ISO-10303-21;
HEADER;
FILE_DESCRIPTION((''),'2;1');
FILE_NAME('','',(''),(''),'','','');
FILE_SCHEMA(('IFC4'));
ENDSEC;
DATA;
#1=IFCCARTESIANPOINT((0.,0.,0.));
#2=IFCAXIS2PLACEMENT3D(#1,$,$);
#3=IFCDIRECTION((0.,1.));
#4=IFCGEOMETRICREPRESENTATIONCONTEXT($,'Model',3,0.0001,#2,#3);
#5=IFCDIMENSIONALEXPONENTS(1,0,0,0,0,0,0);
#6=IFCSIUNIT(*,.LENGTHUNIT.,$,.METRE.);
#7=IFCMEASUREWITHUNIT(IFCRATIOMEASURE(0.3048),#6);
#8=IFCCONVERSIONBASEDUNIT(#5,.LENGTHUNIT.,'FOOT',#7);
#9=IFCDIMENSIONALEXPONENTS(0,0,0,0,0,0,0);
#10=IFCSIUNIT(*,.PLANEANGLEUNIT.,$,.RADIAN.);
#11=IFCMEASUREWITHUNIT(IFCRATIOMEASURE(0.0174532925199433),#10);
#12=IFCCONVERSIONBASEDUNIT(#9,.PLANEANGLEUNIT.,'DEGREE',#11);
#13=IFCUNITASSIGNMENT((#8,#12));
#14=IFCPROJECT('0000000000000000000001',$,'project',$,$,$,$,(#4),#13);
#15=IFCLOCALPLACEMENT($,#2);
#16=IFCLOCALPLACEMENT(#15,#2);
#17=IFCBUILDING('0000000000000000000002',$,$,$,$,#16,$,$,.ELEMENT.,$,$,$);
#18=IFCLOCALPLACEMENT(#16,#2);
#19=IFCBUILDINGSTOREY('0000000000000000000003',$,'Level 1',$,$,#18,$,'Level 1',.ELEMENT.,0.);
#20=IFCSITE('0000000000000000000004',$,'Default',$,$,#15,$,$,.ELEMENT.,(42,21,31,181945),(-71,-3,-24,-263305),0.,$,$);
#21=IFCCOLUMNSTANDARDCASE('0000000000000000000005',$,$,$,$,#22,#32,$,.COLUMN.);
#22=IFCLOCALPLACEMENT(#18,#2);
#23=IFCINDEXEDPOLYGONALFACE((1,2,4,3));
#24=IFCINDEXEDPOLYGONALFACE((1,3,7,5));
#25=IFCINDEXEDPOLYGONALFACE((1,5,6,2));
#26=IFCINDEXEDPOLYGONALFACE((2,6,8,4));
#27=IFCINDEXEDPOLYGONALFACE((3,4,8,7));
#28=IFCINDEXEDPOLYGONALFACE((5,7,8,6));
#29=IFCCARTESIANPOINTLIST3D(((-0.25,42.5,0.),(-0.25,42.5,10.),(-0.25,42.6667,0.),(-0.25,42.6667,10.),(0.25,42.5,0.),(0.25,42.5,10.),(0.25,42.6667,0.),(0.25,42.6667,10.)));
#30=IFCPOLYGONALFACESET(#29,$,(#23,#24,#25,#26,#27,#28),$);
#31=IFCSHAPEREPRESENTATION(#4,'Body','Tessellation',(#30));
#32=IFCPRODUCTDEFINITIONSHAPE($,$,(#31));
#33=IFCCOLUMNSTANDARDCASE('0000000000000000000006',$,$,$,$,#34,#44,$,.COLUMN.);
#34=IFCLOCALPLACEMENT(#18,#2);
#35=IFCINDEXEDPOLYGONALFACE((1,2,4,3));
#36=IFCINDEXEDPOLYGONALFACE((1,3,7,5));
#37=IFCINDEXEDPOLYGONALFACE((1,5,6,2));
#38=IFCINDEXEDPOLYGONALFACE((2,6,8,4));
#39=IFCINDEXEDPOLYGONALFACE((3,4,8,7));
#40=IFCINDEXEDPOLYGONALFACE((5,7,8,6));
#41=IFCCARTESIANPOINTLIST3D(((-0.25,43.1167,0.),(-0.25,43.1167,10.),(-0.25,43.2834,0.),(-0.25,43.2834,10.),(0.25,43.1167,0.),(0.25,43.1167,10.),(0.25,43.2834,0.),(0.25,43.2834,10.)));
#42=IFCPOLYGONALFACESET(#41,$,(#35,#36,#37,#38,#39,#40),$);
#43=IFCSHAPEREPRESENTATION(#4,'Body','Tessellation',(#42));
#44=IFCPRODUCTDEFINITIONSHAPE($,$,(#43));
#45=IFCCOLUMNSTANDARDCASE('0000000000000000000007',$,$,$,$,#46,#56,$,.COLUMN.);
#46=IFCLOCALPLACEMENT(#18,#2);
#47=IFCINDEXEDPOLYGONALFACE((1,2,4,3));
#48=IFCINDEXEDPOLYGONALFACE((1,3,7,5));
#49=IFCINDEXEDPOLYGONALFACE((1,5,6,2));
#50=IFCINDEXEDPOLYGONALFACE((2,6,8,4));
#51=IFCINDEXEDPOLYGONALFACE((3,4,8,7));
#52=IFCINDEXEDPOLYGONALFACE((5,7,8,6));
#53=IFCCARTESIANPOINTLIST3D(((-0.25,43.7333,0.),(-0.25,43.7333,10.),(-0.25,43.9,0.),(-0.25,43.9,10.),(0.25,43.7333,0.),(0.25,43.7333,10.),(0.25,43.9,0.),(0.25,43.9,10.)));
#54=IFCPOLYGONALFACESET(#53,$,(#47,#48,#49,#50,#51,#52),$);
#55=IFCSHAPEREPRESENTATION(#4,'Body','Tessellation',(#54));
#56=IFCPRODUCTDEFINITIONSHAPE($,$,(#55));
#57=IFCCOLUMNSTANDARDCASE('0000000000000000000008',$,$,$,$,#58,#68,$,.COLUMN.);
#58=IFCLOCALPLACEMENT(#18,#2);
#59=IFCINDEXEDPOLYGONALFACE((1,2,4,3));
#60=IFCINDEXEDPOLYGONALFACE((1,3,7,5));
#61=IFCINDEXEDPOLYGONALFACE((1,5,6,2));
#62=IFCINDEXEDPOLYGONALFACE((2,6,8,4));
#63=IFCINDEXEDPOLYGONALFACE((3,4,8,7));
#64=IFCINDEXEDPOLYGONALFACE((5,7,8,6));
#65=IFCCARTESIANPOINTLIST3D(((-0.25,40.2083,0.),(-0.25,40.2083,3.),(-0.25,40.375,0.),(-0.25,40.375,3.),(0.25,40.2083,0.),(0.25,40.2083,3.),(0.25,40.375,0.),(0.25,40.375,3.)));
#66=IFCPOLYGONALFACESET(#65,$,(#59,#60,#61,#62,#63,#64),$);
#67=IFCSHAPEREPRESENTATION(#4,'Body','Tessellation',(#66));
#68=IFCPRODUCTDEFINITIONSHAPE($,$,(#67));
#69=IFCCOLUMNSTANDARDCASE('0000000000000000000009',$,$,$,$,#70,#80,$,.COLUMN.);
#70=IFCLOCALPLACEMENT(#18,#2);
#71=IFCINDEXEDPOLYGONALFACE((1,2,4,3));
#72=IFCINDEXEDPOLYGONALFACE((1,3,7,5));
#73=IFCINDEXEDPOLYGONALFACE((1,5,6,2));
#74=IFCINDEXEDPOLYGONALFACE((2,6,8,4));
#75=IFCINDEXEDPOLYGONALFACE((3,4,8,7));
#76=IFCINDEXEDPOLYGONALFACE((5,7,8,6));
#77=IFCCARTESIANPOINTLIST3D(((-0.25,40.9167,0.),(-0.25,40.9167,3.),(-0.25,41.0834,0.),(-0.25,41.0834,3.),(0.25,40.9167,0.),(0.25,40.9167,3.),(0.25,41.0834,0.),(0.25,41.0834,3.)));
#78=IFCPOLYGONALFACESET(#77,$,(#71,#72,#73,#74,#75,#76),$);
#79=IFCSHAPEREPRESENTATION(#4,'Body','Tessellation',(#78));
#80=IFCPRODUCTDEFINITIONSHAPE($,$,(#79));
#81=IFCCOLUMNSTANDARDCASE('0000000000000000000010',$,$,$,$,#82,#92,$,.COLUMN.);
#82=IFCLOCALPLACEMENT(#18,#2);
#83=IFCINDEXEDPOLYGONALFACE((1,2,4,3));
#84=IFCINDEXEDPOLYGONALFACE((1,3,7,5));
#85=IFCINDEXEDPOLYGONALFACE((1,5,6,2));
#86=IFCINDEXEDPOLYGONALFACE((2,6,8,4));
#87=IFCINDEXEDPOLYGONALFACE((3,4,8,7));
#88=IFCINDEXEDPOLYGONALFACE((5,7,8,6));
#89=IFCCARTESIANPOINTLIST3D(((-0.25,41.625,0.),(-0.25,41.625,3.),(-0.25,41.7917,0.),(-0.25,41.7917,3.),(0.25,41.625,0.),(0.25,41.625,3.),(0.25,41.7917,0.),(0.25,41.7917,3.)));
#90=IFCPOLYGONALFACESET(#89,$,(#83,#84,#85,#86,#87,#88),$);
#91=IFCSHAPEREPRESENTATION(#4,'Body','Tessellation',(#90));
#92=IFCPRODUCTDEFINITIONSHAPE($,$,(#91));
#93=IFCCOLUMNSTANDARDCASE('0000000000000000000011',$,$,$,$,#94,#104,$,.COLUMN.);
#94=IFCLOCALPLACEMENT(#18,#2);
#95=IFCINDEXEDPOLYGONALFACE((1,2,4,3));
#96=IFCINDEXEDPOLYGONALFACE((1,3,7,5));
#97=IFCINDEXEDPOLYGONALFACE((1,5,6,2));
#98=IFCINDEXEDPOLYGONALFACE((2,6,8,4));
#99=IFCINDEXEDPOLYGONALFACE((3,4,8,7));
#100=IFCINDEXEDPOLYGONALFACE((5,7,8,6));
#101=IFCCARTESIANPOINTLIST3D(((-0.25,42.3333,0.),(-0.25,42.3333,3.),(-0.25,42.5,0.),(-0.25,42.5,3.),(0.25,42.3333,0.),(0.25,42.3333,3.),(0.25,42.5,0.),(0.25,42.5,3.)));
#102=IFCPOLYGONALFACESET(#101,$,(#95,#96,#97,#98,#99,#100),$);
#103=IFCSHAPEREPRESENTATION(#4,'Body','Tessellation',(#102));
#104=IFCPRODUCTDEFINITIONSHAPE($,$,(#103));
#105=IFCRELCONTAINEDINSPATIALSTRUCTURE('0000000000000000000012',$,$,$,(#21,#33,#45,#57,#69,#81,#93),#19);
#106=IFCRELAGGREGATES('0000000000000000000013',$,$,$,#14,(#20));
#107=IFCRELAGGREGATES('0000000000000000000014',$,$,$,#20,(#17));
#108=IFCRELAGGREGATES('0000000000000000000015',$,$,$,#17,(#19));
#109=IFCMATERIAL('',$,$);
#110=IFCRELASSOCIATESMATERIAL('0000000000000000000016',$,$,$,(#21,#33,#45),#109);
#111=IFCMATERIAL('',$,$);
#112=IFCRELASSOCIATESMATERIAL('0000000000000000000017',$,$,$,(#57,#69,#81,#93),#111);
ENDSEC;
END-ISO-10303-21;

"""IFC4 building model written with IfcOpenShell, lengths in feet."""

from ifc_helpers import new_model, entity, si_unit, converted_unit, direction, frame, origin, place, context, project, spatial, rectangle, extrude, material, element, save


model = new_model("IFC4")

# Units and contexts
model_context = context("Model", 3, precision=0.0001, world=origin(), true_north=direction((0.0, 1.0)))
ifc_project = project(units=[converted_unit("LENGTHUNIT", "FOOT", entity("IfcRatioMeasure", 0.3048), si_unit("LENGTHUNIT", "METRE"), dimensions=[1, 0, 0, 0, 0, 0, 0]), converted_unit("PLANEANGLEUNIT", "DEGREE", entity("IfcRatioMeasure", 0.0174532925199433), si_unit("PLANEANGLEUNIT", "RADIAN"), dimensions=[0, 0, 0, 0, 0, 0, 0])], contexts=[model_context])

# Site, building, storey
site_placement = place(None, origin())
site = spatial("IfcSite", under=ifc_project, at=site_placement, Name="Default", CompositionType="ELEMENT", RefLatitude=(42, 21, 31, 181945), RefLongitude=(-71, -3, -24, -263305), RefElevation=0.0)
building_placement = place(site_placement, origin())
building = spatial("IfcBuilding", under=site, at=building_placement, CompositionType="ELEMENT")
storey_placement = place(building_placement, origin())
storey = spatial("IfcBuildingStorey", under=building, at=storey_placement, Name="Level 1", LongName="Level 1", CompositionType="ELEMENT", Elevation=0.0)

# Columns
ifc_material_1 = material(Name="")
placement = place(storey_placement, frame((0.0, -0.25, 0.0), z_axis=(0.0, 0.0, 1.0), x_axis=(0.0, 1.0, 0.0)))
for number, where, z_axis, x_axis in (
    (1, (42.8334, 0.0, 0.0), (0.0, 0.0, 1.0), (1.0, 0.0, 0.0)),
    (2, (43.45, 0.0, 0.0), (0.0, 0.0, 1.0), (1.0, 0.0, 0.0)),
    (3, (44.0667, 0.0, 0.0), (0.0, 0.0, 1.0), (1.0, 0.0, 0.0)),
):
    element("IfcColumnStandardCase", number, at=place(placement, frame(where, z_axis=z_axis, x_axis=x_axis)), inside=storey, material=ifc_material_1, PredefinedType="COLUMN", context=model_context, shape_type="SweptSolid", body=[
        extrude(rectangle(XDim=0.1667, YDim=0.5), origin(), (0.0, 0.0, 1.0), 10.0),
    ])
ifc_material_2 = material(Name="")
for number, where, z_axis, x_axis in (
    (4, (40.5417, 0.0, 0.0), (0.0, 0.0, 1.0), (1.0, 0.0, 0.0)),
    (5, (41.25, 0.0, 0.0), (0.0, 0.0, 1.0), (1.0, 0.0, 0.0)),
    (6, (41.9583, 0.0, 0.0), (0.0, 0.0, 1.0), (1.0, 0.0, 0.0)),
    (7, (42.6667, 0.0, 0.0), (0.0, 0.0, 1.0), (1.0, 0.0, 0.0)),
):
    element("IfcColumnStandardCase", number, at=place(placement, frame(where, z_axis=z_axis, x_axis=x_axis)), inside=storey, material=ifc_material_2, PredefinedType="COLUMN", context=model_context, shape_type="SweptSolid", body=[
        extrude(rectangle(XDim=0.1667, YDim=0.5), origin(), (0.0, 0.0, 1.0), 3.0),
    ])

save(model, "model.ifc")
